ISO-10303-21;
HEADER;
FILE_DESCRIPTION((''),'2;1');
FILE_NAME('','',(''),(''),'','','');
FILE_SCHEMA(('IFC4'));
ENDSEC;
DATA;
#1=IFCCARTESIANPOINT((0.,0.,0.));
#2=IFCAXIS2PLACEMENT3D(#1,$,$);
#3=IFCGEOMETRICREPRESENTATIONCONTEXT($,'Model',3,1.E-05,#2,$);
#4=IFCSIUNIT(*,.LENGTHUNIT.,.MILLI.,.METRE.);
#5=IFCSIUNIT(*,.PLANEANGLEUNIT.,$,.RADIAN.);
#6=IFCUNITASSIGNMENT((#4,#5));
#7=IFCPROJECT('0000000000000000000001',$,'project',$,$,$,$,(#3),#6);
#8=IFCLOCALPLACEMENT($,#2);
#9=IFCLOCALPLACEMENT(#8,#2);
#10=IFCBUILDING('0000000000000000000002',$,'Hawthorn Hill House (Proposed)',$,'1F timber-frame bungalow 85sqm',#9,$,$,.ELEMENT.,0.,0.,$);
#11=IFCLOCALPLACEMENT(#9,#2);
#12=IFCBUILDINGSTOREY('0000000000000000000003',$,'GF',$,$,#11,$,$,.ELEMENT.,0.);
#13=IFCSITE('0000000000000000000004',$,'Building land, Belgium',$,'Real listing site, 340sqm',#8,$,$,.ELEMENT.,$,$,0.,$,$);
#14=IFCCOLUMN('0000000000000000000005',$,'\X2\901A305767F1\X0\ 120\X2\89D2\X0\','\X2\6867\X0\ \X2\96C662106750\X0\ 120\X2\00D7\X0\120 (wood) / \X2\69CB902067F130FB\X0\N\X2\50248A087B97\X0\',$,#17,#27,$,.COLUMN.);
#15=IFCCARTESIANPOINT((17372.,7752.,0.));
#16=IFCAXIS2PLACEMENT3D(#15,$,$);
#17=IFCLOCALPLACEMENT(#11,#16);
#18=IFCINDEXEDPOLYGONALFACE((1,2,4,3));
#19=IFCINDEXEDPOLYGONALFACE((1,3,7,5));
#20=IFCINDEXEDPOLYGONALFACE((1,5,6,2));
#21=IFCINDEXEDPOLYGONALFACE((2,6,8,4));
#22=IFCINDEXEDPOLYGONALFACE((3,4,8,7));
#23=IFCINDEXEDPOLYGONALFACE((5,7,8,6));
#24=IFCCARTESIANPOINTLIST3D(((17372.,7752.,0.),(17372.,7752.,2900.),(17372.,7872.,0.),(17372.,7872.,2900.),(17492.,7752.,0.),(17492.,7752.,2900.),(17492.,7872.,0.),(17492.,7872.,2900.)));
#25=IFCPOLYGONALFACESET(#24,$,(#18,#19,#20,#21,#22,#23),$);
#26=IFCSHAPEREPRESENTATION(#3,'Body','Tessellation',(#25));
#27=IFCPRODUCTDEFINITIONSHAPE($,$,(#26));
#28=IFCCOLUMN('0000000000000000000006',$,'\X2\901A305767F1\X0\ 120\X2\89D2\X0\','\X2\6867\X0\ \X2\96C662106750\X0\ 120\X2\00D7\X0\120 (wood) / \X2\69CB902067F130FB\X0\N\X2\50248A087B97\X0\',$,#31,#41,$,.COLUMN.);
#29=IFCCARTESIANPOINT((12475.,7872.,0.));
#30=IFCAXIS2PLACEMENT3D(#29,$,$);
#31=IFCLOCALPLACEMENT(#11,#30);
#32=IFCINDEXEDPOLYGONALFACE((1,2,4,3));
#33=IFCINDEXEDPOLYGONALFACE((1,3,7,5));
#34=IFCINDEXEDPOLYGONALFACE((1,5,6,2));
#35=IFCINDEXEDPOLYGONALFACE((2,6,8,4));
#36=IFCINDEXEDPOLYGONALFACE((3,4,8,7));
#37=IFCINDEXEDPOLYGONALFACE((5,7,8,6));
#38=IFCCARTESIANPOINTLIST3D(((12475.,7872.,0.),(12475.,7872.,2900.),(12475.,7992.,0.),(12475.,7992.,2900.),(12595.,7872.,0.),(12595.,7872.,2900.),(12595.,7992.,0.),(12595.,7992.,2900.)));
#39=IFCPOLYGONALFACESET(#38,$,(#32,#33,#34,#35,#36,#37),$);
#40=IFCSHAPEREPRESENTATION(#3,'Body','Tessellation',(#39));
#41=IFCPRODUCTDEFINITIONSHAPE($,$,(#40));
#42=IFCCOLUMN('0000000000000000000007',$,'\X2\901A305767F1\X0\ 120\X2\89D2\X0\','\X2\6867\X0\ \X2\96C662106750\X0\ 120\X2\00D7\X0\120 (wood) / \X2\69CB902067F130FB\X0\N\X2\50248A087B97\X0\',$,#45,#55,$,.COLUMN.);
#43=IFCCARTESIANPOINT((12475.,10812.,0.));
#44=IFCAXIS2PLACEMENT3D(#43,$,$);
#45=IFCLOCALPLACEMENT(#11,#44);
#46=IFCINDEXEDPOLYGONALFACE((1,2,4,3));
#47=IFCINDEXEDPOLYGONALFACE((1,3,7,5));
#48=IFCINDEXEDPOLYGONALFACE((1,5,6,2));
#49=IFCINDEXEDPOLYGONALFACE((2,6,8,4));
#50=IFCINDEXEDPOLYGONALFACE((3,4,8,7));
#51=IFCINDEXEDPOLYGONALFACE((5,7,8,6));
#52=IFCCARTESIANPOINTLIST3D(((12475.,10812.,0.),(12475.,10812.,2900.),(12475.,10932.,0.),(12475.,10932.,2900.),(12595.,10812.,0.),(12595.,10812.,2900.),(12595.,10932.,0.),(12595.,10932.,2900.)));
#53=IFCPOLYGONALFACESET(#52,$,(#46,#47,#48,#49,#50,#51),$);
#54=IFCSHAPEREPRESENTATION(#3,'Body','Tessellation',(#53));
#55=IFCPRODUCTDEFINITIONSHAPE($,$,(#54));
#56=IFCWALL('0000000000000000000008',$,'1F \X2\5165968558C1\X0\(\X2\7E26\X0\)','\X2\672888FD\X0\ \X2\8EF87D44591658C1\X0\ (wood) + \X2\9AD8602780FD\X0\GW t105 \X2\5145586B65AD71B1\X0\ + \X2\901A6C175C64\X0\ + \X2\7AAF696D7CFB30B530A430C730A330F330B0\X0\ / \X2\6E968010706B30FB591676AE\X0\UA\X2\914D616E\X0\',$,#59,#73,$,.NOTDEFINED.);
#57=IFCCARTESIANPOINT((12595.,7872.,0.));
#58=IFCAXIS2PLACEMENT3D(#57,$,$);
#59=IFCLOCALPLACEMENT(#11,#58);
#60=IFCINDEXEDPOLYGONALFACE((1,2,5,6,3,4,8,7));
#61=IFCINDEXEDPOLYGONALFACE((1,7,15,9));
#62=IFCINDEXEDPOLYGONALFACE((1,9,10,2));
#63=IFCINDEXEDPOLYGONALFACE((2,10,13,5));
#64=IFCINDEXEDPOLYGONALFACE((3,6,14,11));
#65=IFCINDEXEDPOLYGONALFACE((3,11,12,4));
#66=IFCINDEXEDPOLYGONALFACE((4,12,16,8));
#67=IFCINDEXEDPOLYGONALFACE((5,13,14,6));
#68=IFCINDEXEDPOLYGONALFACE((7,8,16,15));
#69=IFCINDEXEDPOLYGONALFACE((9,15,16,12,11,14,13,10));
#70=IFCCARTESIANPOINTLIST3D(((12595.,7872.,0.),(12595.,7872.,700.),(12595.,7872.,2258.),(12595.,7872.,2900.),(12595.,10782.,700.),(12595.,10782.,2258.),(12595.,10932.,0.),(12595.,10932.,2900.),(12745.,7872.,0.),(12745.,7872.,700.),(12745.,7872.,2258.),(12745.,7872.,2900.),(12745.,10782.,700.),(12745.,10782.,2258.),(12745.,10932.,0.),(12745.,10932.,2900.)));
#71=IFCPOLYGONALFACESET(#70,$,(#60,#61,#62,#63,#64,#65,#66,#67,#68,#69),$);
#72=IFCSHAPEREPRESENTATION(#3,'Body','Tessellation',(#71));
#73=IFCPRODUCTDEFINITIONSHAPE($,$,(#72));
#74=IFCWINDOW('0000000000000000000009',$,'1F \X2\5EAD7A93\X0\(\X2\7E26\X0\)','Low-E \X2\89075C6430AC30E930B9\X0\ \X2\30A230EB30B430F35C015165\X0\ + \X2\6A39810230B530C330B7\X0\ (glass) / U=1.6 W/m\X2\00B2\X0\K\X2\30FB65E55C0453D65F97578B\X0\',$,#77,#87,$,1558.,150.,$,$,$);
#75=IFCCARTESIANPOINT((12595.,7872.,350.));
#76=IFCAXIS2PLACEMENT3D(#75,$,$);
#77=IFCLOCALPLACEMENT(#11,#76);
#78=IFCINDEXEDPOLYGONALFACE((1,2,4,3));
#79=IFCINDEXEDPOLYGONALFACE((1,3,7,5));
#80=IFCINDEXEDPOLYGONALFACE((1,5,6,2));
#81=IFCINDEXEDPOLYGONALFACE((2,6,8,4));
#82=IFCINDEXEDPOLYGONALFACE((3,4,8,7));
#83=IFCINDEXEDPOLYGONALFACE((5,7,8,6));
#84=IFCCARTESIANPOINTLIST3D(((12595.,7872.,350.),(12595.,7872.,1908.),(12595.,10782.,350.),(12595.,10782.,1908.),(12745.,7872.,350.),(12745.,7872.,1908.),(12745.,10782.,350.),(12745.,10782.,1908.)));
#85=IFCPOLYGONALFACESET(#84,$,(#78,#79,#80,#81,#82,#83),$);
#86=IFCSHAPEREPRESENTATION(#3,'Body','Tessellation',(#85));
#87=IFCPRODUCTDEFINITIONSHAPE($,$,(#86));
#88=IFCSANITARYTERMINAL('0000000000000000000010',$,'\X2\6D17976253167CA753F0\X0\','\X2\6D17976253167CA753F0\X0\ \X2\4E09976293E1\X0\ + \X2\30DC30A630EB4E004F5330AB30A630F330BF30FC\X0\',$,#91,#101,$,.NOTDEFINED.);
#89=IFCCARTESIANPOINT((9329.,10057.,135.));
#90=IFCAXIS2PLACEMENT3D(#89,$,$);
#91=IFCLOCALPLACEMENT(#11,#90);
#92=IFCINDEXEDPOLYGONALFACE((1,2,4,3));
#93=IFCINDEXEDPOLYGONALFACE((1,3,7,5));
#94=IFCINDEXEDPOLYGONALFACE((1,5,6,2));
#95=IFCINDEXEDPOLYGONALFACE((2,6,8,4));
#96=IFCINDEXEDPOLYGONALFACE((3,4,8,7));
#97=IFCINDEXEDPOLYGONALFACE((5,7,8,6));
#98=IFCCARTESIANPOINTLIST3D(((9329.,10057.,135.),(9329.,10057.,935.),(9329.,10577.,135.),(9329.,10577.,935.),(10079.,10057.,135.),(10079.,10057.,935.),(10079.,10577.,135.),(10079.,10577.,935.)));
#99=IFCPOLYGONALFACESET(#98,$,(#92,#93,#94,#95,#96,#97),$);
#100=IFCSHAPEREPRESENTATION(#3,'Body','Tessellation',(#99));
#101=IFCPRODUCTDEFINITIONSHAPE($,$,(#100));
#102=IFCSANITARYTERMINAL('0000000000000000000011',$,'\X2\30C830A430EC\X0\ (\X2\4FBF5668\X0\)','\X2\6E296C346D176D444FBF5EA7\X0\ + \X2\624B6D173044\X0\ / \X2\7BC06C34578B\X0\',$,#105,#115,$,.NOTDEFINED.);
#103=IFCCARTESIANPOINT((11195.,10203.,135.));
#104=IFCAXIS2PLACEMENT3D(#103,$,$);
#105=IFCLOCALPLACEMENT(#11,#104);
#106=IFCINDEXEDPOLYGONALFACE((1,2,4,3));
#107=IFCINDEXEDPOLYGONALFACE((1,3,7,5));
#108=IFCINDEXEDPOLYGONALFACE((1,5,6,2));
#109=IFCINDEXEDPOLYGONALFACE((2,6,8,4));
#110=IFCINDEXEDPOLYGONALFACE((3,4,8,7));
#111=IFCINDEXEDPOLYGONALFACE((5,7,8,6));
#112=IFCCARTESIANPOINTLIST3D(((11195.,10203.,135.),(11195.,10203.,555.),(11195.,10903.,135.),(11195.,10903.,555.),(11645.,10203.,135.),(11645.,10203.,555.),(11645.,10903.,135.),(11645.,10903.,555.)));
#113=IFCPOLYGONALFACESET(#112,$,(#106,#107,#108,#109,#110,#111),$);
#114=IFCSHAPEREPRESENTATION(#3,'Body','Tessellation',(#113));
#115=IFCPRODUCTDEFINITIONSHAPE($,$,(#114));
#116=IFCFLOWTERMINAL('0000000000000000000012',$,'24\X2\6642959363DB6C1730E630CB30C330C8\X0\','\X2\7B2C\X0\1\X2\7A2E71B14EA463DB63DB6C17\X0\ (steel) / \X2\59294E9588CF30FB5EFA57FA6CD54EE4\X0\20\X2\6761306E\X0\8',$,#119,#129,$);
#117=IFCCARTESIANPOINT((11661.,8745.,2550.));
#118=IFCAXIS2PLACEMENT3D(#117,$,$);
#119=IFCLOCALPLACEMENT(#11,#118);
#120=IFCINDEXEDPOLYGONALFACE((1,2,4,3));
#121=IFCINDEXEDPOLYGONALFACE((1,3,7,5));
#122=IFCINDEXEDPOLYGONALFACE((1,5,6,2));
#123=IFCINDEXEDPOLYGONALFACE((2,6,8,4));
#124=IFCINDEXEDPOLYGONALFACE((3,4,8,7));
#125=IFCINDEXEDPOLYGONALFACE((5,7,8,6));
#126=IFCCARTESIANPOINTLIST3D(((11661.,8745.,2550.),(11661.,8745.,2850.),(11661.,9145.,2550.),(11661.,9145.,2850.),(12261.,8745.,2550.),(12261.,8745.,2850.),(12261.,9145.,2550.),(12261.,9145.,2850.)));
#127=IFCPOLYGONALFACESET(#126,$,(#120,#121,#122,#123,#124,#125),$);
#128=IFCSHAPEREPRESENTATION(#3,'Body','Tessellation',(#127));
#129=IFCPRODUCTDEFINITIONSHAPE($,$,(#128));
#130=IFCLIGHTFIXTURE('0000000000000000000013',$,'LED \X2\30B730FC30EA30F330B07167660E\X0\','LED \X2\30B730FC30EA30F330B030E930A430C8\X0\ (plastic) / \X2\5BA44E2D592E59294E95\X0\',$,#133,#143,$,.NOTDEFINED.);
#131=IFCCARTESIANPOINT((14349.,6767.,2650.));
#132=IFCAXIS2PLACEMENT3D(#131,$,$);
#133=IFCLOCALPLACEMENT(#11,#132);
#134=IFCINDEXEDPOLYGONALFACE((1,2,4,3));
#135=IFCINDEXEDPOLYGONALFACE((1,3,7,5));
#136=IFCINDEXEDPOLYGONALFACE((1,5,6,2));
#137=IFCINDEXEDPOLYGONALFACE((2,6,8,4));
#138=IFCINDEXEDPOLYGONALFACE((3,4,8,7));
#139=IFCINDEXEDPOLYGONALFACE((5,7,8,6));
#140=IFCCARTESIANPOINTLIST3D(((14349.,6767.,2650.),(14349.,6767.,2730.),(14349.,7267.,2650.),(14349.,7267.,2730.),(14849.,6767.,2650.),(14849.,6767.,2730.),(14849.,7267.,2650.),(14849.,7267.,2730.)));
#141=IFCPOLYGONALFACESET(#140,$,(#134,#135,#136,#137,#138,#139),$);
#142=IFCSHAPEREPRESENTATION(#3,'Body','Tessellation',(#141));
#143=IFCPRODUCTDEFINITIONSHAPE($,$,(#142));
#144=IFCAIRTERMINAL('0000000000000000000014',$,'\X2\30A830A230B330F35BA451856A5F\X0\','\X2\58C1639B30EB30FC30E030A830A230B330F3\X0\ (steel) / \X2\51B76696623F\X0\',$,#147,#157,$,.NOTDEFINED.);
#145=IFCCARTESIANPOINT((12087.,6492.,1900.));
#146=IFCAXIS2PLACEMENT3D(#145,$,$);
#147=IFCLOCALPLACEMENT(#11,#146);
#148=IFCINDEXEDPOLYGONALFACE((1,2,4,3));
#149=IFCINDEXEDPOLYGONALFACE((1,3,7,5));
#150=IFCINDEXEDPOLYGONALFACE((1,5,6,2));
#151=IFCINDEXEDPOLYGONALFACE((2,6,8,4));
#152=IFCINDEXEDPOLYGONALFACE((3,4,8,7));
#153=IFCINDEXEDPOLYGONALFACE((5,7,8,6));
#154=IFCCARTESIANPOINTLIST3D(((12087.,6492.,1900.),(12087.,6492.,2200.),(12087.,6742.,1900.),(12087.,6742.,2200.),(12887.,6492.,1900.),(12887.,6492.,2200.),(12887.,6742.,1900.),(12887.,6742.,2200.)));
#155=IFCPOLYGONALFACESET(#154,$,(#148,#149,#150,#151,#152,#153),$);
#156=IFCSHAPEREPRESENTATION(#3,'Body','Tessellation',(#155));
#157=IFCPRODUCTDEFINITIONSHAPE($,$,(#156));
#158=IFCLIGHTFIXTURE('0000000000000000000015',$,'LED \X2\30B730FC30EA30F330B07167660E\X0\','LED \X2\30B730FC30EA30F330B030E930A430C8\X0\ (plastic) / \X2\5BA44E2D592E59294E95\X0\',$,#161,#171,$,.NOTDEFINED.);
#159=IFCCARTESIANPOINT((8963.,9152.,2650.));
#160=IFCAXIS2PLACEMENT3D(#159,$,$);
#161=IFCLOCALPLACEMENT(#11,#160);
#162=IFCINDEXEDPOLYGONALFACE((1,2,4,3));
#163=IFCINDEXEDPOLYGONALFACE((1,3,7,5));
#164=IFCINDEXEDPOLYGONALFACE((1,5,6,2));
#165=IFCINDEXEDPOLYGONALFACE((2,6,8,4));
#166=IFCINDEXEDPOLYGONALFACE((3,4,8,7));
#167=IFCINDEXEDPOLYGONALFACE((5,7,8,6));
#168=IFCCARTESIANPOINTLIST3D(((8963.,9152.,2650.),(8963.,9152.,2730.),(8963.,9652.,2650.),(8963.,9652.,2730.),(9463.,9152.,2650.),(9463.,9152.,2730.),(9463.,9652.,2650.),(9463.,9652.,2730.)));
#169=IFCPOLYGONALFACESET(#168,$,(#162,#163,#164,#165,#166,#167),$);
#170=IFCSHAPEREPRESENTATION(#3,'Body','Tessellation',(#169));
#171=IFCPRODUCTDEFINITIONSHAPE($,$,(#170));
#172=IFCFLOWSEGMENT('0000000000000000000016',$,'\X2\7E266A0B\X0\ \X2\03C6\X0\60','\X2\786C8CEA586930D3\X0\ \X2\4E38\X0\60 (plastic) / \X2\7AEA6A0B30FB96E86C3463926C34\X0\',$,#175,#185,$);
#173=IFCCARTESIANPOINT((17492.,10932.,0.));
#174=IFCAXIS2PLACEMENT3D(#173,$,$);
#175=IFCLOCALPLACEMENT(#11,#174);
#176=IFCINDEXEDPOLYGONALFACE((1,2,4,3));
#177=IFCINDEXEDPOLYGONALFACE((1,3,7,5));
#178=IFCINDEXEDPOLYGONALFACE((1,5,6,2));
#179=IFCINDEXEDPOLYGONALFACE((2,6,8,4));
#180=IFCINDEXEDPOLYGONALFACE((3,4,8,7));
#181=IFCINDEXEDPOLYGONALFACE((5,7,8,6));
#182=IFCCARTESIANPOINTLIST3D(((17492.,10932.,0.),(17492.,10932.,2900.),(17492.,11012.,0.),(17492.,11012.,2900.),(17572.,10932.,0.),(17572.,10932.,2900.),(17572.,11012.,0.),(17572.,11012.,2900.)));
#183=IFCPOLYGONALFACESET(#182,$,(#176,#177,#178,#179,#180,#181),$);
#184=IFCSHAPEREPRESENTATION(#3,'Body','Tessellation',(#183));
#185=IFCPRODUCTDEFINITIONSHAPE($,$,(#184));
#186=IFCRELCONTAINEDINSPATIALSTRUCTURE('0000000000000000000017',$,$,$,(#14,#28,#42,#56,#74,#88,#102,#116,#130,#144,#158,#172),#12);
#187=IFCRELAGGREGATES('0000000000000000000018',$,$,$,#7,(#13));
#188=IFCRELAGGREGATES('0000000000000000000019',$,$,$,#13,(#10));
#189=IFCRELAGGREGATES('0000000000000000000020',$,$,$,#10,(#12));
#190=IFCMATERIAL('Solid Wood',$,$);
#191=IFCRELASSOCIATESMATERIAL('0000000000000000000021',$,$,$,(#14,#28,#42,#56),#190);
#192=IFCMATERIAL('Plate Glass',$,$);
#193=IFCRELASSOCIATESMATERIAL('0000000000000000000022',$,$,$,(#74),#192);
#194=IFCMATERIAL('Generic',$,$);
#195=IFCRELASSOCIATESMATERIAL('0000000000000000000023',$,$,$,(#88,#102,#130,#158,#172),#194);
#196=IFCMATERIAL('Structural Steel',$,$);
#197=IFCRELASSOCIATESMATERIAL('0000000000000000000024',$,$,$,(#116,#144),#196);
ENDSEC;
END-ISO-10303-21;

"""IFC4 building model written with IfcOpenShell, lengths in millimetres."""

from ifc_helpers import new_model, si_unit, frame, frame_2d, origin, place, context, project, spatial, rectangle, extrude, material, element, fill, save


model = new_model("IFC4")

# Units and contexts
model_context = context("Model", 3, precision=1e-05, world=origin())
ifc_project = project(units=[si_unit("LENGTHUNIT", "METRE", prefix="MILLI"), si_unit("PLANEANGLEUNIT", "RADIAN")], contexts=[model_context])

# Site, building, storey
site_placement = place(None, origin())
site = spatial("IfcSite", under=ifc_project, at=site_placement, Name="Building land, Belgium", ObjectType="Real listing site, 340sqm", CompositionType="ELEMENT", RefElevation=0.0)
building_placement = place(site_placement, origin())
building = spatial("IfcBuilding", under=site, at=building_placement, Name="Hawthorn Hill House (Proposed)", ObjectType="1F timber-frame bungalow 85sqm", CompositionType="ELEMENT", ElevationOfRefHeight=0.0, ElevationOfTerrain=0.0)
storey_placement = place(building_placement, origin())
storey = spatial("IfcBuildingStorey", under=building, at=storey_placement, Name="GF", CompositionType="ELEMENT", Elevation=0.0)

# Columns
ifc_material_1 = material(Name="Solid Wood")
column_1_placement = place(storey_placement, frame((17372.0, 7752.0, 0.0)))
element("IfcColumn", 1, at=column_1_placement, inside=storey, material=ifc_material_1, Name="通し柱 120角", Description="桧 集成材 120×120 (wood) / 構造柱・N値計算", PredefinedType="COLUMN", context=model_context, shape_type="SweptSolid", body=[
    extrude(rectangle(XDim=120.0, YDim=120.0, at=frame_2d((60.0, 60.0))), frame((17372.0, 7752.0, 0.0)), (0.0, 0.0, 1.0), 2900.0),
])
column_2_placement = place(storey_placement, frame((12475.0, 7872.0, 0.0)))
element("IfcColumn", 2, at=column_2_placement, inside=storey, material=ifc_material_1, Name="通し柱 120角", Description="桧 集成材 120×120 (wood) / 構造柱・N値計算", PredefinedType="COLUMN", context=model_context, shape_type="SweptSolid", body=[
    extrude(rectangle(XDim=120.0, YDim=120.0, at=frame_2d((60.0, 60.0))), frame((12475.0, 7872.0, 0.0)), (0.0, 0.0, 1.0), 2900.0),
])
column_3_placement = place(storey_placement, frame((12475.0, 10812.0, 0.0)))
element("IfcColumn", 3, at=column_3_placement, inside=storey, material=ifc_material_1, Name="通し柱 120角", Description="桧 集成材 120×120 (wood) / 構造柱・N値計算", PredefinedType="COLUMN", context=model_context, shape_type="SweptSolid", body=[
    extrude(rectangle(XDim=120.0, YDim=120.0, at=frame_2d((60.0, 60.0))), frame((12475.0, 10812.0, 0.0)), (0.0, 0.0, 1.0), 2900.0),
])

# Wall, opening, window
wall_1_placement = place(storey_placement, frame((12595.0, 7872.0, 0.0)))
wall_1 = element("IfcWall", 4, at=wall_1_placement, inside=storey, material=ifc_material_1, Name="1F 入隅壁(縦)", Description="木製 軸組外壁 (wood) + 高性能GW t105 充填断熱 + 通気層 + 窯業系サイディング / 準耐火・外皮UA配慮", PredefinedType="NOTDEFINED", context=model_context, shape_type="SweptSolid", body=[
    extrude(rectangle(XDim=150.0, YDim=3060.0, at=frame_2d((75.0, 1530.0))), frame((12595.0, 7872.0, 0.0)), (0.0, 0.0, 1.0), 2900.0),
])
opening_placement = place(storey_placement, frame((12595.0, 7872.0, 350.0)))
opening = element("IfcOpeningElement", 5, at=opening_placement, cuts=wall_1, PredefinedType="NOTDEFINED", context=model_context, shape_type="SweptSolid", body=[
    extrude(rectangle(XDim=150.0, YDim=2910.0, at=frame_2d((75.0, 1455.0))), frame((12595.0, 7872.0, 350.0)), (0.0, 0.0, 1.0), 1558.0),
])
ifc_material_2 = material(Name="Plate Glass")
window_placement = place(storey_placement, frame((12595.0, 7872.0, 350.0)))
window = element("IfcWindow", 6, at=window_placement, inside=storey, material=ifc_material_2, Name="1F 庭窓(縦)", Description="Low-E 複層ガラス アルゴン封入 + 樹脂サッシ (glass) / U=1.6 W/m²K・日射取得型", OverallHeight=1558.0, OverallWidth=150.0, context=model_context, shape_type="SweptSolid", body=[
    extrude(rectangle(XDim=150.0, YDim=2910.0, at=frame_2d((75.0, 1455.0))), frame((12595.0, 7872.0, 350.0)), (0.0, 0.0, 1.0), 1558.0),
])
fill(opening, window)

# Sanitary terminals
ifc_material_3 = material(Name="Generic")
sanitary_terminal_1_placement = place(storey_placement, frame((9329.0, 10057.0, 135.0)))
element("IfcSanitaryTerminal", 7, at=sanitary_terminal_1_placement, inside=storey, material=ifc_material_3, Name="洗面化粧台", Description="洗面化粧台 三面鏡 + ボウル一体カウンター", PredefinedType="NOTDEFINED", context=model_context, shape_type="SweptSolid", body=[
    extrude(rectangle(XDim=750.0, YDim=520.0, at=frame_2d((375.0, 260.0))), frame((9329.0, 10057.0, 135.0)), (0.0, 0.0, 1.0), 800.0),
])
sanitary_terminal_2_placement = place(storey_placement, frame((11195.0, 10203.0, 135.0)))
element("IfcSanitaryTerminal", 8, at=sanitary_terminal_2_placement, inside=storey, material=ifc_material_3, Name="トイレ (便器)", Description="温水洗浄便座 + 手洗い / 節水型", PredefinedType="NOTDEFINED", context=model_context, shape_type="SweptSolid", body=[
    extrude(rectangle(XDim=450.0, YDim=700.0, at=frame_2d((225.0, 350.0))), frame((11195.0, 10203.0, 135.0)), (0.0, 0.0, 1.0), 420.0),
])

# Flow terminal
ifc_material_4 = material(Name="Structural Steel")
flow_terminal_placement = place(storey_placement, frame((11661.0, 8745.0, 2550.0)))
element("IfcFlowTerminal", 9, at=flow_terminal_placement, inside=storey, material=ifc_material_4, Name="24時間換気ユニット", Description="第1種熱交換換気 (steel) / 天井裏・建基法令20条の8", context=model_context, shape_type="SweptSolid", body=[
    extrude(rectangle(XDim=600.0, YDim=400.0, at=frame_2d((300.0, 200.0))), frame((11661.0, 8745.0, 2550.0)), (0.0, 0.0, 1.0), 300.0),
])

# Light fixture
light_fixture_1_placement = place(storey_placement, frame((14349.0, 6767.0, 2650.0)))
element("IfcLightFixture", 10, at=light_fixture_1_placement, inside=storey, material=ifc_material_3, Name="LED シーリング照明", Description="LED シーリングライト (plastic) / 室中央天井", PredefinedType="NOTDEFINED", context=model_context, shape_type="SweptSolid", body=[
    extrude(rectangle(XDim=500.0, YDim=500.0, at=frame_2d((250.0, 250.0))), frame((14349.0, 6767.0, 2650.0)), (0.0, 0.0, 1.0), 80.0),
])

# Air terminal
air_terminal_placement = place(storey_placement, frame((12087.0, 6492.0, 1900.0)))
element("IfcAirTerminal", 11, at=air_terminal_placement, inside=storey, material=ifc_material_4, Name="エアコン室内機", Description="壁掛ルームエアコン (steel) / 冷暖房", PredefinedType="NOTDEFINED", context=model_context, shape_type="SweptSolid", body=[
    extrude(rectangle(XDim=800.0, YDim=250.0, at=frame_2d((400.0, 125.0))), frame((12087.0, 6492.0, 1900.0)), (0.0, 0.0, 1.0), 300.0),
])

# Light fixture
light_fixture_2_placement = place(storey_placement, frame((8963.0, 9152.0, 2650.0)))
element("IfcLightFixture", 12, at=light_fixture_2_placement, inside=storey, material=ifc_material_3, Name="LED シーリング照明", Description="LED シーリングライト (plastic) / 室中央天井", PredefinedType="NOTDEFINED", context=model_context, shape_type="SweptSolid", body=[
    extrude(rectangle(XDim=500.0, YDim=500.0, at=frame_2d((250.0, 250.0))), frame((8963.0, 9152.0, 2650.0)), (0.0, 0.0, 1.0), 80.0),
])

# Flow segment
flow_segment_placement = place(storey_placement, frame((17492.0, 10932.0, 0.0)))
element("IfcFlowSegment", 13, at=flow_segment_placement, inside=storey, material=ifc_material_3, Name="縦樋 φ60", Description="硬質塩ビ 丸60 (plastic) / 竪樋・雨水排水", context=model_context, shape_type="SweptSolid", body=[
    extrude(rectangle(XDim=80.0, YDim=80.0, at=frame_2d((40.0, 40.0))), frame((17492.0, 10932.0, 0.0)), (0.0, 0.0, 1.0), 2900.0),
])

save(model, "model.ifc")
